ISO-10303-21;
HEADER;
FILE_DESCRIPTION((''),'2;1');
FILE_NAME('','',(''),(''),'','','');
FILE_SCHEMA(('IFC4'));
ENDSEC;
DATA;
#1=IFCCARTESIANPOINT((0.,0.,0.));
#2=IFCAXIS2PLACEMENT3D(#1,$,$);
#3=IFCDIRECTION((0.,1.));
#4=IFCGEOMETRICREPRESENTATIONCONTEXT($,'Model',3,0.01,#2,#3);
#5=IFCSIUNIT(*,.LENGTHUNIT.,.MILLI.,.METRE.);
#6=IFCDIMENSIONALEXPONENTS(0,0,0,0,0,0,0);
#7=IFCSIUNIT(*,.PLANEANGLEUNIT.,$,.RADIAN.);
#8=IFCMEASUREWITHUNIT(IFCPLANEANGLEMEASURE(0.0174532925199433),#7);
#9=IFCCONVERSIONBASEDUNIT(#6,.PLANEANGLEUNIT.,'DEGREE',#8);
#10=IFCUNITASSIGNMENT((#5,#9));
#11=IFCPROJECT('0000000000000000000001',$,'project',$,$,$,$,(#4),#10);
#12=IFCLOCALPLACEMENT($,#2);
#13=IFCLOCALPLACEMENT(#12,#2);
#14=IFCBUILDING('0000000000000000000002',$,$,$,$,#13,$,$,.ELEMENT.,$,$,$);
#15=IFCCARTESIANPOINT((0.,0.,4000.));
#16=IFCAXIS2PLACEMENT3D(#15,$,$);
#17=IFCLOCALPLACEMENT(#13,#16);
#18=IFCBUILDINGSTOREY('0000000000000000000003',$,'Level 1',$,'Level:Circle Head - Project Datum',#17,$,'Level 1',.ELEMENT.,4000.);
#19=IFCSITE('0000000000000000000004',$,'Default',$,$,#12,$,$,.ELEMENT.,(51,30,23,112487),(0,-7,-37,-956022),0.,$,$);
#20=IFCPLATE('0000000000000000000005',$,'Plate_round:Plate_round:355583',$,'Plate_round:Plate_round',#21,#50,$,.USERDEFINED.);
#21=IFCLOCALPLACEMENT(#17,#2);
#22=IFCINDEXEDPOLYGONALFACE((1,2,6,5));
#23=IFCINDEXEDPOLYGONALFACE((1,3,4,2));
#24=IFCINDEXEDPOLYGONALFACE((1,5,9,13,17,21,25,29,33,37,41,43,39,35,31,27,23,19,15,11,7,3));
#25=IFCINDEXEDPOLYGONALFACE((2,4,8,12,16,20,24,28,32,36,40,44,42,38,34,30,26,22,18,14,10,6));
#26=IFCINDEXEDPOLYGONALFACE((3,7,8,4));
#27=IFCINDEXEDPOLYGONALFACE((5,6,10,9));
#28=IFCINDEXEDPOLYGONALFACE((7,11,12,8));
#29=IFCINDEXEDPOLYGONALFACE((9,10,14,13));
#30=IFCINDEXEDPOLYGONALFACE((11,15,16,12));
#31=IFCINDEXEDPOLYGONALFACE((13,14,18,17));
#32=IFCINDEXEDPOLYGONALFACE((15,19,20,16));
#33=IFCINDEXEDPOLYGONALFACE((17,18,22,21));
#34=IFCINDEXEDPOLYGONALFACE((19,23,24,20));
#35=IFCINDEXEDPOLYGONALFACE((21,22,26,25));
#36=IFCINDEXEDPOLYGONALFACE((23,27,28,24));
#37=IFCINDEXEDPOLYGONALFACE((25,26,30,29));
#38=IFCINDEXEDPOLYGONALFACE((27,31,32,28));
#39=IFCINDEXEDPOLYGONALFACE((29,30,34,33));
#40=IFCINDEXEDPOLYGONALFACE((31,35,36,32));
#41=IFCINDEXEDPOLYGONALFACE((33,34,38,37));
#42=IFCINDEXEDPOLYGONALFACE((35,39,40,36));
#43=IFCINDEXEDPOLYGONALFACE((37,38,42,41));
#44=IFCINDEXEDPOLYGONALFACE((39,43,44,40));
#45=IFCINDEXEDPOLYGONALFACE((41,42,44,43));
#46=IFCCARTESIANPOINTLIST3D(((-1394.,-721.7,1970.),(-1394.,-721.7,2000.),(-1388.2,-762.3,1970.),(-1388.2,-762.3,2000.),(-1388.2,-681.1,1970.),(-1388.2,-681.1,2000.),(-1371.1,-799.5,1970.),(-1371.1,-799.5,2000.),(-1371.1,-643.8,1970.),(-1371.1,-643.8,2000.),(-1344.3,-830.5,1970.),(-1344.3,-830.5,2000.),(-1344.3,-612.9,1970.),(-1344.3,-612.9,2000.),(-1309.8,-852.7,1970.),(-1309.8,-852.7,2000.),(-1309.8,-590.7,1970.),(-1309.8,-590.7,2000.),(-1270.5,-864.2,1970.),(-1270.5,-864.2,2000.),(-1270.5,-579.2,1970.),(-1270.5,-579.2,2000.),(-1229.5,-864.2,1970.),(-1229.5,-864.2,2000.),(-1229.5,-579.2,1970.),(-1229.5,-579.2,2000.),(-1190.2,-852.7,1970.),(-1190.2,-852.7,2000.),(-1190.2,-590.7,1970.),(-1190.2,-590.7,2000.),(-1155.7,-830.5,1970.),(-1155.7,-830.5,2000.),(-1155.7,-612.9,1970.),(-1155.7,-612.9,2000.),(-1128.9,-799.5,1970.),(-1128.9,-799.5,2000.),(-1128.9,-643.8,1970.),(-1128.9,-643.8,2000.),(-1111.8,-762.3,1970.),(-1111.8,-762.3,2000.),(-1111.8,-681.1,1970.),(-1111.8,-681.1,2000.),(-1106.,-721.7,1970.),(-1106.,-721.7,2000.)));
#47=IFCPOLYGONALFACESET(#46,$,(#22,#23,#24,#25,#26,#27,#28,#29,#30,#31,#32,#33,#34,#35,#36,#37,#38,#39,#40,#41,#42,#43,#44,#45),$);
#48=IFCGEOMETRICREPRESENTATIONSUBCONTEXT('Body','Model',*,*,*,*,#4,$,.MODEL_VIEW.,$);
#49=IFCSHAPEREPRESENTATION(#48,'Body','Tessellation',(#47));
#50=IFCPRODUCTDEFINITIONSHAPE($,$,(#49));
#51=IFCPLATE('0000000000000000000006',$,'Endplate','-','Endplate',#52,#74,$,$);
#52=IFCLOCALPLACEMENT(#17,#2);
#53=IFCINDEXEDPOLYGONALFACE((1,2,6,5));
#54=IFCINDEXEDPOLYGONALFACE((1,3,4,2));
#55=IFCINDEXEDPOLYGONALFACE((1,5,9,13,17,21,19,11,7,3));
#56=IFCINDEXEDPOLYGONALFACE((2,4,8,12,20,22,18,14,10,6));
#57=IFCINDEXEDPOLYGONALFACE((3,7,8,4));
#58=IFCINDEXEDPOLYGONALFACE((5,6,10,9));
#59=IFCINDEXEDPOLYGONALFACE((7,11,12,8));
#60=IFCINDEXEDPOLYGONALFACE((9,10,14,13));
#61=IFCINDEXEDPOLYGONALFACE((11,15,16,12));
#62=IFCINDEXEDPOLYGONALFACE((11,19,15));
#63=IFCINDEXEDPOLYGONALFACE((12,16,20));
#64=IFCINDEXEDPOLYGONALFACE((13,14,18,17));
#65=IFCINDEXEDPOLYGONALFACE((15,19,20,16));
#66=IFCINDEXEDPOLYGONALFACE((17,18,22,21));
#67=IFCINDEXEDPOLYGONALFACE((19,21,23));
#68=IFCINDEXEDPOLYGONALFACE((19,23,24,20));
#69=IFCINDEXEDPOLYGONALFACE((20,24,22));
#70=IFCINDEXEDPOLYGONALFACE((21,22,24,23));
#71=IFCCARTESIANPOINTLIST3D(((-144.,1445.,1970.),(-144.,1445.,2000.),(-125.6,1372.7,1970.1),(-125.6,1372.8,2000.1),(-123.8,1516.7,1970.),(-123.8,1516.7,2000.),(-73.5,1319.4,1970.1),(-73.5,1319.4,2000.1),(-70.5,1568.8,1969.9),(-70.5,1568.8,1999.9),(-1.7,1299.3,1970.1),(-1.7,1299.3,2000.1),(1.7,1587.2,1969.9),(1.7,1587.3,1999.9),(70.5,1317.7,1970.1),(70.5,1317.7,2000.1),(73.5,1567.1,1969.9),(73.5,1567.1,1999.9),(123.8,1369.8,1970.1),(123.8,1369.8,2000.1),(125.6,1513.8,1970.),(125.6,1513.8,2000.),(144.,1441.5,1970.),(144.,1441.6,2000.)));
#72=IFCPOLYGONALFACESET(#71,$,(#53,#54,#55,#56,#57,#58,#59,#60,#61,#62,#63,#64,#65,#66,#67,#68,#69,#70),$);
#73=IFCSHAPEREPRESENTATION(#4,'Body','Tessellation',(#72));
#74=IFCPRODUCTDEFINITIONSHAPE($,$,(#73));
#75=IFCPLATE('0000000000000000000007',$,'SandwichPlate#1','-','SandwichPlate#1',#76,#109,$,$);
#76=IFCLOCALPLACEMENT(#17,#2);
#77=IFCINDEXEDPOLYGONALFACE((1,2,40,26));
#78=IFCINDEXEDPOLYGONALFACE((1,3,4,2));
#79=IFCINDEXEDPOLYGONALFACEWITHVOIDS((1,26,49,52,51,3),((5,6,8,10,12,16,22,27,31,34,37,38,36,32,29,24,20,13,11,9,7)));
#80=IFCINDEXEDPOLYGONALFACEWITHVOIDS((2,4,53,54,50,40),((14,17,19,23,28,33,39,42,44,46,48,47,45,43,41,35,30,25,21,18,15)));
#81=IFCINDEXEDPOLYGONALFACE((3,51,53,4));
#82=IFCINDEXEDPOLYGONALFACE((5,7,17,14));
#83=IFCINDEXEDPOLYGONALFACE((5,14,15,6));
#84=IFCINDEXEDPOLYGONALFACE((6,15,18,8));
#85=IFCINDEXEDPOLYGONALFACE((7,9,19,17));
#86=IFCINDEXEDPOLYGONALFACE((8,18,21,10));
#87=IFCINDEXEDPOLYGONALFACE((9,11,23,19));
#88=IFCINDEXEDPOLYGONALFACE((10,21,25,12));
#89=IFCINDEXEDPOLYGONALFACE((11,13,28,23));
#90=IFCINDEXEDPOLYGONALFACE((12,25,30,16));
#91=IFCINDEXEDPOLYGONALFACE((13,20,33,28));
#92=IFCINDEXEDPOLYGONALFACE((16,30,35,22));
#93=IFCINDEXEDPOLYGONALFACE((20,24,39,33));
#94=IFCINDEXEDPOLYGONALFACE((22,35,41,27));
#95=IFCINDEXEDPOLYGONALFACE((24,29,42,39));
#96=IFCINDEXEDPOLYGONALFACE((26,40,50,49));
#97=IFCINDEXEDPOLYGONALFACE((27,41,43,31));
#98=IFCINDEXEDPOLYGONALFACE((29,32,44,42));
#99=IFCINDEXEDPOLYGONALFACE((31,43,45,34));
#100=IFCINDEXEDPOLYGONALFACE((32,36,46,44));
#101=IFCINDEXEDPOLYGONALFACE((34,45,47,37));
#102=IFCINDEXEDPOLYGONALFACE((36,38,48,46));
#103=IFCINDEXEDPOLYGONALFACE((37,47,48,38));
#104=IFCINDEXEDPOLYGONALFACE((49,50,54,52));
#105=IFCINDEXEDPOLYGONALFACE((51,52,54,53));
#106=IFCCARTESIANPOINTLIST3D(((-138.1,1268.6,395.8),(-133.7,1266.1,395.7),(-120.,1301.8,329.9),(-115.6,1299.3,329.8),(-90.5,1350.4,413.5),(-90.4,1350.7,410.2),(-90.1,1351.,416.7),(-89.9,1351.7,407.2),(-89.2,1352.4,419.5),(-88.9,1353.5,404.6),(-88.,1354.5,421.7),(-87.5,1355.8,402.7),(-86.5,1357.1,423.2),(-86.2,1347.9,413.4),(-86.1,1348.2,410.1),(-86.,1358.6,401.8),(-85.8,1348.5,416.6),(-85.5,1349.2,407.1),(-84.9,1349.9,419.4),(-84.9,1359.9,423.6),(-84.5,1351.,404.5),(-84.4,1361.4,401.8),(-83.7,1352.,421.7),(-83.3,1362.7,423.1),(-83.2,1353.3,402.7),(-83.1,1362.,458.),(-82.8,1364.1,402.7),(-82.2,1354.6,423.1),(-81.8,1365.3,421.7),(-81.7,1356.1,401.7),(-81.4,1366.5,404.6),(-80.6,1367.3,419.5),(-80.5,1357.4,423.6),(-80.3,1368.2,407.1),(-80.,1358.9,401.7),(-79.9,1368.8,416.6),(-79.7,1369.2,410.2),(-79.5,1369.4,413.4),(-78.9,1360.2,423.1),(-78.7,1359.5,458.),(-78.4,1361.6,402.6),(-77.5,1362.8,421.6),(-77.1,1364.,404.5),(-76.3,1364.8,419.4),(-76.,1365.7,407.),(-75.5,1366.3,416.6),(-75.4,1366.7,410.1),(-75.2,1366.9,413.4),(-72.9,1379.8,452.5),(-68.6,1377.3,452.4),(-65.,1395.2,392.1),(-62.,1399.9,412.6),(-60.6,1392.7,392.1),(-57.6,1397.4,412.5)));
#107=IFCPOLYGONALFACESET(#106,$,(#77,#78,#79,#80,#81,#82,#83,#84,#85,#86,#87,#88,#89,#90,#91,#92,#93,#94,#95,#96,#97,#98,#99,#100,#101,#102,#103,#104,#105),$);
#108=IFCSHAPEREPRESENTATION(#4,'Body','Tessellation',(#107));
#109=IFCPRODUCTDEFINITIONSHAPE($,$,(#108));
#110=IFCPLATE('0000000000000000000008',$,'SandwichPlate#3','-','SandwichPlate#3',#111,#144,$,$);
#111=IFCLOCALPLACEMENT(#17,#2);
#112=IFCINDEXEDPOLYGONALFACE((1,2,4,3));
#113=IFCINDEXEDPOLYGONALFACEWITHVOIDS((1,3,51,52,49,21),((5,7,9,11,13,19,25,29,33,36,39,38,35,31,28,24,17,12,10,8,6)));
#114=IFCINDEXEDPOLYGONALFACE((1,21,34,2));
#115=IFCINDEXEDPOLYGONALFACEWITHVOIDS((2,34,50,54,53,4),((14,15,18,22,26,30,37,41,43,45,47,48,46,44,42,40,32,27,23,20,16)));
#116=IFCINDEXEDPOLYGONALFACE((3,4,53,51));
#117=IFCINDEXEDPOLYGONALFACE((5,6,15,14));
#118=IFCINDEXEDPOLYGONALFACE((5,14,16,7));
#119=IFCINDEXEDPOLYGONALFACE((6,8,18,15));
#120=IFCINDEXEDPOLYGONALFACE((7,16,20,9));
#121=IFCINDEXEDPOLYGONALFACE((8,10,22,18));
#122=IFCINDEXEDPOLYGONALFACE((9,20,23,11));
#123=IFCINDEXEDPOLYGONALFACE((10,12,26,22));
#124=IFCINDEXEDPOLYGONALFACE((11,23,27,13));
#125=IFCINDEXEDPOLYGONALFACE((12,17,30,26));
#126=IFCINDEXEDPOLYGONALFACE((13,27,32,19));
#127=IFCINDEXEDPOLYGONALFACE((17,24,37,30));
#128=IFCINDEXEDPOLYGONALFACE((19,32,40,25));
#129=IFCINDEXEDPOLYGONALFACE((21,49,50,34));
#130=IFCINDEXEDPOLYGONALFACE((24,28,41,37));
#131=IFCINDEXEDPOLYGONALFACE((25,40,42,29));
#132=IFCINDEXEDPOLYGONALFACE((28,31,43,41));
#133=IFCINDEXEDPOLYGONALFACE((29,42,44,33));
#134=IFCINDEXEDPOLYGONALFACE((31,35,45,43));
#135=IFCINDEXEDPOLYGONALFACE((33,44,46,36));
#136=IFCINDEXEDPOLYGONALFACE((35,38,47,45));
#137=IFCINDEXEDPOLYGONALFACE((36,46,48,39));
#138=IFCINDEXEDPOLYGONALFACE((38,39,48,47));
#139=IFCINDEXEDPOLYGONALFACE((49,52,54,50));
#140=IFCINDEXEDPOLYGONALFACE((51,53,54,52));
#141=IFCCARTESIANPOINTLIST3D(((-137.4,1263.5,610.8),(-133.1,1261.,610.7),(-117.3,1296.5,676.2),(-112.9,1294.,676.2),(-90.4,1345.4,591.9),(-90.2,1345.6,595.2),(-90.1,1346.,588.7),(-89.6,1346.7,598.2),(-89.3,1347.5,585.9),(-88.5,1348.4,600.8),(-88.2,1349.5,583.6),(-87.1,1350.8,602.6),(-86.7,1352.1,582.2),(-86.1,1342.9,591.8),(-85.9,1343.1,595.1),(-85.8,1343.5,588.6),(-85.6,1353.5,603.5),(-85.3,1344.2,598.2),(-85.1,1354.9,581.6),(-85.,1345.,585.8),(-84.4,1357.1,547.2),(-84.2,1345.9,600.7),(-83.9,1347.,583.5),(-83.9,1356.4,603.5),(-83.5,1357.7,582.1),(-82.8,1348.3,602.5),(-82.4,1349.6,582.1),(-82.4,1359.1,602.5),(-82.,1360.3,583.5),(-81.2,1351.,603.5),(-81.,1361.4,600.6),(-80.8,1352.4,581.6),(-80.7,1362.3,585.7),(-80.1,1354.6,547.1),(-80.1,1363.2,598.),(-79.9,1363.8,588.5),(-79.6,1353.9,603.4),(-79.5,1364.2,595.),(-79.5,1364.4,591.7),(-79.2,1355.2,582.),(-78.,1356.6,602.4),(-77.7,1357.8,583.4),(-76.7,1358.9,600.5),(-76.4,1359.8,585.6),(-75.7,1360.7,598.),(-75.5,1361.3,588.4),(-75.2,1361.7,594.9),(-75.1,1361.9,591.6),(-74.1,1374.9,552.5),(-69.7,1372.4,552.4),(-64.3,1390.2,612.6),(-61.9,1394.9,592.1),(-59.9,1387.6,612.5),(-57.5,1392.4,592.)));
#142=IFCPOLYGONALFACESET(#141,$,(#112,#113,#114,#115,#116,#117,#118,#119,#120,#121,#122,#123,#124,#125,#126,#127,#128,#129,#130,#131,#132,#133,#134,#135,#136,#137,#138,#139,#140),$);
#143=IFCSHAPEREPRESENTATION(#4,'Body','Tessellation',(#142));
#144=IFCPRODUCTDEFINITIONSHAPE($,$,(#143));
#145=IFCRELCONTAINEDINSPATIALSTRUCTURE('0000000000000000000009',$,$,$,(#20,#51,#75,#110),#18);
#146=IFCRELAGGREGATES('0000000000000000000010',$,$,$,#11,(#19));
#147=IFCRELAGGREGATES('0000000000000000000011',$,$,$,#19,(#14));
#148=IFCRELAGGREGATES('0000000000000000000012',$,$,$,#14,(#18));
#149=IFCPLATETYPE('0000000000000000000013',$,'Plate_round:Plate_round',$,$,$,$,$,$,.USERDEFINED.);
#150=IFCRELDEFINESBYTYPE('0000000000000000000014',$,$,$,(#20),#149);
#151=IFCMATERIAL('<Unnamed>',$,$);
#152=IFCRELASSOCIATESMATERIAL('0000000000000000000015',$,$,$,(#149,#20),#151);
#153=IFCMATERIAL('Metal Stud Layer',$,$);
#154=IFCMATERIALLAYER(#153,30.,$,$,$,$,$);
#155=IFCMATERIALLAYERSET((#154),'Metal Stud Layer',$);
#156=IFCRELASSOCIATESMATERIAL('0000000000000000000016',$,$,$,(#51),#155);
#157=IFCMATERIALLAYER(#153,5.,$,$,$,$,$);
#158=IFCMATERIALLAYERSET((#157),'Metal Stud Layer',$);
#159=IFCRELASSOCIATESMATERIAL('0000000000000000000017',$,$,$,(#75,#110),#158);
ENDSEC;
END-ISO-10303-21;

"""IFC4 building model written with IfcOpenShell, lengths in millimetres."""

from ifc_helpers import new_model, entity, si_unit, converted_unit, point, direction, frame, frame_2d, origin, origin_with_axes, origin_2d_with_axis, place, context, subcontext, project, spatial, polyline, arc, indexed_curve, circle_curve, line_curve, trimmed, segment, composite_curve, circle, outline, extrude, source, transform, mapped, material, layer, layer_set, type_object, type_shapes, element, save


model = new_model("IFC4")

# Units and contexts
model_context = context("Model", 3, precision=0.01, world=origin(), true_north=direction((0.0, 1.0)))
body_context = subcontext(model_context, "Body", "Model", "MODEL_VIEW")
ifc_project = project(units=[si_unit("LENGTHUNIT", "METRE", prefix="MILLI"), converted_unit("PLANEANGLEUNIT", "DEGREE", entity("IfcPlaneAngleMeasure", 0.0174532925199433), si_unit("PLANEANGLEUNIT", "RADIAN"), dimensions=[0, 0, 0, 0, 0, 0, 0])], contexts=[model_context])

# Site, building, storey
site_placement = place(None, origin())
site = spatial("IfcSite", under=ifc_project, at=site_placement, Name="Default", CompositionType="ELEMENT", RefLatitude=(51, 30, 23, 112487), RefLongitude=(0, -7, -37, -956022), RefElevation=0.0)
building_placement = place(site_placement, origin())
building = spatial("IfcBuilding", under=site, at=building_placement, CompositionType="ELEMENT")
storey_placement = place(building_placement, frame((0.0, 0.0, 4000.0)))
storey = spatial("IfcBuildingStorey", under=building, at=storey_placement, Name="Level 1", ObjectType="Level:Circle Head - Project Datum", LongName="Level 1", CompositionType="ELEMENT", Elevation=4000.0)

# Plate
ifc_material_1 = material(Name="<Unnamed>")
plate_type = type_object("IfcPlateType", Name="Plate_round:Plate_round", PredefinedType="USERDEFINED", material=ifc_material_1)
shared_shape = source(origin(), body_context, "Body", "SweptSolid", [
    extrude(outline(indexed_curve([(-144.0, 0.0), (0.0, -144.0), (144.0, 0.0), (0.0, 144.0)], segments=[arc(1, 2, 3), arc(3, 4, 1)], self_intersect=False)), origin(), (0.0, 0.0, 1.0), 30.0),
])
type_shapes(plate_type, [shared_shape])
plate_1_placement = place(storey_placement, frame((-1250.0, -721.7, 1970.0)))
element("IfcPlate", 1, at=plate_1_placement, inside=storey, type_object=plate_type, material=ifc_material_1, Name="Plate_round:Plate_round:355583", ObjectType="Plate_round:Plate_round", PredefinedType="USERDEFINED", context=body_context, shape_type="MappedRepresentation", body=[
    mapped(shared_shape, transform((0.0, 0.0, 0.0), scale=1.0)),
])

# Plates, openings
ifc_material_2 = material(Name="Metal Stud Layer")
ifc_layer_1 = layer(ifc_material_2, 30.0)
ifc_layer_set_1 = layer_set([ifc_layer_1], Name="Metal Stud Layer")
plate_2_placement = place(storey_placement, frame((-144.0, 1445.0, 1970.0), z_axis=(0.0, 0.000811, 1.0), x_axis=(-0.011883, -0.999929, 0.000811)))
plate_2 = element("IfcPlate", 2, at=plate_2_placement, inside=storey, material=ifc_layer_set_1, Name="Endplate", Description="-", ObjectType="Endplate", context=model_context, shape_type="SweptSolid", body=[
    extrude(outline(polyline([(144.0, 0.0), (144.0, 288.0), (-144.0, 288.0), (-144.0, 0.0), (144.0, 0.0)])), origin_with_axes(), (0.0, 0.0, 1.0), 30.0),
])
opening_1_placement = place(plate_2_placement, frame((0.0, 0.0, 0.0), z_axis=(0.0, 0.0, 1.0), x_axis=(1.0, 0.0, 0.0)))
element("IfcOpeningElement", 3, at=opening_1_placement, cuts=plate_2, ObjectType="Opening", context=model_context, shape_type="SweptSolid", body=[
    extrude(outline(composite_curve([segment(trimmed(line_curve((144.0, 0.0), (0.0, 1.0), 144.0), [point((144.0, 0.0))], [point((144.0, 144.0))], True, "CARTESIAN"), True, "CONTINUOUS"), segment(trimmed(circle_curve(frame_2d((0.0, 144.0), x_axis=(-1.0, 0.0)), 144.0), [point((144.0, 144.0))], [point((0.0, 0.0))], False, "CARTESIAN"), True, "CONTINUOUS"), segment(trimmed(line_curve((0.0, 0.0), (1.0, 0.0), 144.0), [point((0.0, 0.0))], [point((144.0, 0.0))], True, "CARTESIAN"), True, "CONTINUOUS")], self_intersect="UNKNOWN")), origin(), (0.0, 0.0, 1.0), 30.0),
])
opening_2_placement = place(plate_2_placement, frame((0.0, 0.0, 0.0), z_axis=(0.0, 0.0, 1.0), x_axis=(1.0, 0.0, 0.0)))
element("IfcOpeningElement", 4, at=opening_2_placement, cuts=plate_2, ObjectType="Opening", context=model_context, shape_type="SweptSolid", body=[
    extrude(outline(composite_curve([segment(trimmed(line_curve((144.0, 288.0), (-1.0, 0.0), 144.0), [point((144.0, 288.0))], [point((0.0, 288.0))], True, "CARTESIAN"), True, "CONTINUOUS"), segment(trimmed(circle_curve(frame_2d((0.0, 144.0), x_axis=(-1.0, 0.0)), 144.0), [point((0.0, 288.0))], [point((144.0, 144.0))], False, "CARTESIAN"), True, "CONTINUOUS"), segment(trimmed(line_curve((144.0, 144.0), (0.0, 1.0), 144.0), [point((144.0, 144.0))], [point((144.0, 288.0))], True, "CARTESIAN"), True, "CONTINUOUS")], self_intersect="UNKNOWN")), origin(), (0.0, 0.0, 1.0), 30.0),
])
opening_3_placement = place(plate_2_placement, frame((0.0, 0.0, 0.0), z_axis=(0.0, 0.0, 1.0), x_axis=(1.0, 0.0, 0.0)))
element("IfcOpeningElement", 5, at=opening_3_placement, cuts=plate_2, ObjectType="Opening", context=model_context, shape_type="SweptSolid", body=[
    extrude(outline(composite_curve([segment(trimmed(line_curve((-144.0, 288.0), (0.0, -1.0), 144.0), [point((-144.0, 288.0))], [point((-144.0, 144.0))], True, "CARTESIAN"), True, "CONTINUOUS"), segment(trimmed(circle_curve(frame_2d((0.0, 144.0), x_axis=(-1.0, 0.0)), 144.0), [point((-144.0, 144.0))], [point((0.0, 288.0))], False, "CARTESIAN"), True, "CONTINUOUS"), segment(trimmed(line_curve((0.0, 288.0), (-1.0, 0.0), 144.0), [point((0.0, 288.0))], [point((-144.0, 288.0))], True, "CARTESIAN"), True, "CONTINUOUS")], self_intersect="UNKNOWN")), origin(), (0.0, 0.0, 1.0), 30.0),
])
opening_4_placement = place(plate_2_placement, frame((0.0, 0.0, 0.0), z_axis=(0.0, 0.0, 1.0), x_axis=(1.0, 0.0, 0.0)))
element("IfcOpeningElement", 6, at=opening_4_placement, cuts=plate_2, ObjectType="Opening", context=model_context, shape_type="SweptSolid", body=[
    extrude(outline(composite_curve([segment(trimmed(line_curve((-144.0, 0.0), (1.0, 0.0), 144.0), [point((-144.0, 0.0))], [point((0.0, 0.0))], True, "CARTESIAN"), True, "CONTINUOUS"), segment(trimmed(circle_curve(frame_2d((0.0, 144.0), x_axis=(-1.0, 0.0)), 144.0), [point((0.0, 0.0))], [point((-144.0, 144.0))], False, "CARTESIAN"), True, "CONTINUOUS"), segment(trimmed(line_curve((-144.0, 144.0), (0.0, -1.0), 144.0), [point((-144.0, 144.0))], [point((-144.0, 0.0))], True, "CARTESIAN"), True, "CONTINUOUS")], self_intersect="UNKNOWN")), origin(), (0.0, 0.0, 1.0), 30.0),
])
ifc_layer_2 = layer(ifc_material_2, 5.0)
ifc_layer_set_2 = layer_set([ifc_layer_2], Name="Metal Stud Layer")
plate_3_placement = place(storey_placement, frame((-58.4, 1406.5, 399.6), z_axis=(0.865935, -0.499948, -0.014432), x_axis=(-0.238139, -0.437501, 0.867112)))
plate_3 = element("IfcPlate", 7, at=plate_3_placement, inside=storey, material=ifc_layer_set_2, Name="SandwichPlate#1", Description="-", ObjectType="SandwichPlate#1", context=model_context, shape_type="SweptSolid", body=[
    extrude(outline(polyline([(0.0, 0.0), (76.0, 0.0), (76.0, 140.0), (0.0, 140.0), (0.0, 0.0)])), origin_with_axes(), (0.0, 0.0, 1.0), 5.0),
])
opening_5_placement = place(plate_3_placement, frame((0.0, 0.0, 0.0), z_axis=(0.0, 0.0, 1.0), x_axis=(1.0, 0.0, 0.0)))
element("IfcOpeningElement", 8, at=opening_5_placement, cuts=plate_3, ObjectType="Opening", context=model_context, shape_type="SweptSolid", body=[
    extrude(outline(polyline([(0.0, 0.0), (15.0, 0.0), (0.0, 15.0), (0.0, 0.0)])), origin(), (0.0, 0.0, 1.0), 5.0),
])
opening_6_placement = place(plate_3_placement, frame((0.0, 0.0, 0.0), z_axis=(0.0, 0.0, 1.0), x_axis=(1.0, 0.0, 0.0)))
element("IfcOpeningElement", 9, at=opening_6_placement, cuts=plate_3, ObjectType="Opening", context=model_context, shape_type="SweptSolid", body=[
    extrude(outline(polyline([(76.0, 0.0), (76.0, 15.0), (61.0, 0.0), (76.0, 0.0)])), origin(), (0.0, 0.0, 1.0), 5.0),
])
opening_7_placement = place(plate_3_placement, frame((38.0, 40.0, -0.5), z_axis=(0.0, 0.0, 1.0), x_axis=(0.0, 1.0, 0.0)))
element("IfcOpeningElement", 10, at=opening_7_placement, cuts=plate_3, ObjectType="Opening", context=model_context, shape_type="SweptSolid", body=[
    extrude(circle(Radius=11.0, at=origin_2d_with_axis()), origin(), (0.0, 0.0, 1.0), 6.0),
])
plate_4_placement = place(storey_placement, frame((-78.0, 1368.4, 539.6), z_axis=(0.865935, -0.499948, -0.014432), x_axis=(0.265222, 0.434531, 0.86072)))
plate_4 = element("IfcPlate", 11, at=plate_4_placement, inside=storey, material=ifc_layer_set_2, Name="SandwichPlate#3", Description="-", ObjectType="SandwichPlate#3", context=model_context, shape_type="SweptSolid", body=[
    extrude(outline(polyline([(0.0, 0.0), (76.0, 0.0), (76.0, 140.0), (0.0, 140.0), (0.0, 0.0)])), origin_with_axes(), (0.0, 0.0, 1.0), 5.0),
])
opening_8_placement = place(plate_4_placement, frame((0.0, 0.0, 0.0), z_axis=(0.0, 0.0, 1.0), x_axis=(1.0, 0.0, 0.0)))
element("IfcOpeningElement", 12, at=opening_8_placement, cuts=plate_4, ObjectType="Opening", context=model_context, shape_type="SweptSolid", body=[
    extrude(outline(polyline([(0.0, 0.0), (15.0, 0.0), (0.0, 15.0), (0.0, 0.0)])), origin(), (0.0, 0.0, 1.0), 5.0),
])
opening_9_placement = place(plate_4_placement, frame((0.0, 0.0, 0.0), z_axis=(0.0, 0.0, 1.0), x_axis=(1.0, 0.0, 0.0)))
element("IfcOpeningElement", 13, at=opening_9_placement, cuts=plate_4, ObjectType="Opening", context=model_context, shape_type="SweptSolid", body=[
    extrude(outline(polyline([(76.0, 0.0), (76.0, 15.0), (61.0, 0.0), (76.0, 0.0)])), origin(), (0.0, 0.0, 1.0), 5.0),
])
opening_10_placement = place(plate_4_placement, frame((38.0, 40.0, -0.5), z_axis=(0.0, 0.0, 1.0), x_axis=(0.0, 1.0, 0.0)))
element("IfcOpeningElement", 14, at=opening_10_placement, cuts=plate_4, ObjectType="Opening", context=model_context, shape_type="SweptSolid", body=[
    extrude(circle(Radius=11.0, at=origin_2d_with_axis()), origin(), (0.0, 0.0, 1.0), 6.0),
])

save(model, "model.ifc")
